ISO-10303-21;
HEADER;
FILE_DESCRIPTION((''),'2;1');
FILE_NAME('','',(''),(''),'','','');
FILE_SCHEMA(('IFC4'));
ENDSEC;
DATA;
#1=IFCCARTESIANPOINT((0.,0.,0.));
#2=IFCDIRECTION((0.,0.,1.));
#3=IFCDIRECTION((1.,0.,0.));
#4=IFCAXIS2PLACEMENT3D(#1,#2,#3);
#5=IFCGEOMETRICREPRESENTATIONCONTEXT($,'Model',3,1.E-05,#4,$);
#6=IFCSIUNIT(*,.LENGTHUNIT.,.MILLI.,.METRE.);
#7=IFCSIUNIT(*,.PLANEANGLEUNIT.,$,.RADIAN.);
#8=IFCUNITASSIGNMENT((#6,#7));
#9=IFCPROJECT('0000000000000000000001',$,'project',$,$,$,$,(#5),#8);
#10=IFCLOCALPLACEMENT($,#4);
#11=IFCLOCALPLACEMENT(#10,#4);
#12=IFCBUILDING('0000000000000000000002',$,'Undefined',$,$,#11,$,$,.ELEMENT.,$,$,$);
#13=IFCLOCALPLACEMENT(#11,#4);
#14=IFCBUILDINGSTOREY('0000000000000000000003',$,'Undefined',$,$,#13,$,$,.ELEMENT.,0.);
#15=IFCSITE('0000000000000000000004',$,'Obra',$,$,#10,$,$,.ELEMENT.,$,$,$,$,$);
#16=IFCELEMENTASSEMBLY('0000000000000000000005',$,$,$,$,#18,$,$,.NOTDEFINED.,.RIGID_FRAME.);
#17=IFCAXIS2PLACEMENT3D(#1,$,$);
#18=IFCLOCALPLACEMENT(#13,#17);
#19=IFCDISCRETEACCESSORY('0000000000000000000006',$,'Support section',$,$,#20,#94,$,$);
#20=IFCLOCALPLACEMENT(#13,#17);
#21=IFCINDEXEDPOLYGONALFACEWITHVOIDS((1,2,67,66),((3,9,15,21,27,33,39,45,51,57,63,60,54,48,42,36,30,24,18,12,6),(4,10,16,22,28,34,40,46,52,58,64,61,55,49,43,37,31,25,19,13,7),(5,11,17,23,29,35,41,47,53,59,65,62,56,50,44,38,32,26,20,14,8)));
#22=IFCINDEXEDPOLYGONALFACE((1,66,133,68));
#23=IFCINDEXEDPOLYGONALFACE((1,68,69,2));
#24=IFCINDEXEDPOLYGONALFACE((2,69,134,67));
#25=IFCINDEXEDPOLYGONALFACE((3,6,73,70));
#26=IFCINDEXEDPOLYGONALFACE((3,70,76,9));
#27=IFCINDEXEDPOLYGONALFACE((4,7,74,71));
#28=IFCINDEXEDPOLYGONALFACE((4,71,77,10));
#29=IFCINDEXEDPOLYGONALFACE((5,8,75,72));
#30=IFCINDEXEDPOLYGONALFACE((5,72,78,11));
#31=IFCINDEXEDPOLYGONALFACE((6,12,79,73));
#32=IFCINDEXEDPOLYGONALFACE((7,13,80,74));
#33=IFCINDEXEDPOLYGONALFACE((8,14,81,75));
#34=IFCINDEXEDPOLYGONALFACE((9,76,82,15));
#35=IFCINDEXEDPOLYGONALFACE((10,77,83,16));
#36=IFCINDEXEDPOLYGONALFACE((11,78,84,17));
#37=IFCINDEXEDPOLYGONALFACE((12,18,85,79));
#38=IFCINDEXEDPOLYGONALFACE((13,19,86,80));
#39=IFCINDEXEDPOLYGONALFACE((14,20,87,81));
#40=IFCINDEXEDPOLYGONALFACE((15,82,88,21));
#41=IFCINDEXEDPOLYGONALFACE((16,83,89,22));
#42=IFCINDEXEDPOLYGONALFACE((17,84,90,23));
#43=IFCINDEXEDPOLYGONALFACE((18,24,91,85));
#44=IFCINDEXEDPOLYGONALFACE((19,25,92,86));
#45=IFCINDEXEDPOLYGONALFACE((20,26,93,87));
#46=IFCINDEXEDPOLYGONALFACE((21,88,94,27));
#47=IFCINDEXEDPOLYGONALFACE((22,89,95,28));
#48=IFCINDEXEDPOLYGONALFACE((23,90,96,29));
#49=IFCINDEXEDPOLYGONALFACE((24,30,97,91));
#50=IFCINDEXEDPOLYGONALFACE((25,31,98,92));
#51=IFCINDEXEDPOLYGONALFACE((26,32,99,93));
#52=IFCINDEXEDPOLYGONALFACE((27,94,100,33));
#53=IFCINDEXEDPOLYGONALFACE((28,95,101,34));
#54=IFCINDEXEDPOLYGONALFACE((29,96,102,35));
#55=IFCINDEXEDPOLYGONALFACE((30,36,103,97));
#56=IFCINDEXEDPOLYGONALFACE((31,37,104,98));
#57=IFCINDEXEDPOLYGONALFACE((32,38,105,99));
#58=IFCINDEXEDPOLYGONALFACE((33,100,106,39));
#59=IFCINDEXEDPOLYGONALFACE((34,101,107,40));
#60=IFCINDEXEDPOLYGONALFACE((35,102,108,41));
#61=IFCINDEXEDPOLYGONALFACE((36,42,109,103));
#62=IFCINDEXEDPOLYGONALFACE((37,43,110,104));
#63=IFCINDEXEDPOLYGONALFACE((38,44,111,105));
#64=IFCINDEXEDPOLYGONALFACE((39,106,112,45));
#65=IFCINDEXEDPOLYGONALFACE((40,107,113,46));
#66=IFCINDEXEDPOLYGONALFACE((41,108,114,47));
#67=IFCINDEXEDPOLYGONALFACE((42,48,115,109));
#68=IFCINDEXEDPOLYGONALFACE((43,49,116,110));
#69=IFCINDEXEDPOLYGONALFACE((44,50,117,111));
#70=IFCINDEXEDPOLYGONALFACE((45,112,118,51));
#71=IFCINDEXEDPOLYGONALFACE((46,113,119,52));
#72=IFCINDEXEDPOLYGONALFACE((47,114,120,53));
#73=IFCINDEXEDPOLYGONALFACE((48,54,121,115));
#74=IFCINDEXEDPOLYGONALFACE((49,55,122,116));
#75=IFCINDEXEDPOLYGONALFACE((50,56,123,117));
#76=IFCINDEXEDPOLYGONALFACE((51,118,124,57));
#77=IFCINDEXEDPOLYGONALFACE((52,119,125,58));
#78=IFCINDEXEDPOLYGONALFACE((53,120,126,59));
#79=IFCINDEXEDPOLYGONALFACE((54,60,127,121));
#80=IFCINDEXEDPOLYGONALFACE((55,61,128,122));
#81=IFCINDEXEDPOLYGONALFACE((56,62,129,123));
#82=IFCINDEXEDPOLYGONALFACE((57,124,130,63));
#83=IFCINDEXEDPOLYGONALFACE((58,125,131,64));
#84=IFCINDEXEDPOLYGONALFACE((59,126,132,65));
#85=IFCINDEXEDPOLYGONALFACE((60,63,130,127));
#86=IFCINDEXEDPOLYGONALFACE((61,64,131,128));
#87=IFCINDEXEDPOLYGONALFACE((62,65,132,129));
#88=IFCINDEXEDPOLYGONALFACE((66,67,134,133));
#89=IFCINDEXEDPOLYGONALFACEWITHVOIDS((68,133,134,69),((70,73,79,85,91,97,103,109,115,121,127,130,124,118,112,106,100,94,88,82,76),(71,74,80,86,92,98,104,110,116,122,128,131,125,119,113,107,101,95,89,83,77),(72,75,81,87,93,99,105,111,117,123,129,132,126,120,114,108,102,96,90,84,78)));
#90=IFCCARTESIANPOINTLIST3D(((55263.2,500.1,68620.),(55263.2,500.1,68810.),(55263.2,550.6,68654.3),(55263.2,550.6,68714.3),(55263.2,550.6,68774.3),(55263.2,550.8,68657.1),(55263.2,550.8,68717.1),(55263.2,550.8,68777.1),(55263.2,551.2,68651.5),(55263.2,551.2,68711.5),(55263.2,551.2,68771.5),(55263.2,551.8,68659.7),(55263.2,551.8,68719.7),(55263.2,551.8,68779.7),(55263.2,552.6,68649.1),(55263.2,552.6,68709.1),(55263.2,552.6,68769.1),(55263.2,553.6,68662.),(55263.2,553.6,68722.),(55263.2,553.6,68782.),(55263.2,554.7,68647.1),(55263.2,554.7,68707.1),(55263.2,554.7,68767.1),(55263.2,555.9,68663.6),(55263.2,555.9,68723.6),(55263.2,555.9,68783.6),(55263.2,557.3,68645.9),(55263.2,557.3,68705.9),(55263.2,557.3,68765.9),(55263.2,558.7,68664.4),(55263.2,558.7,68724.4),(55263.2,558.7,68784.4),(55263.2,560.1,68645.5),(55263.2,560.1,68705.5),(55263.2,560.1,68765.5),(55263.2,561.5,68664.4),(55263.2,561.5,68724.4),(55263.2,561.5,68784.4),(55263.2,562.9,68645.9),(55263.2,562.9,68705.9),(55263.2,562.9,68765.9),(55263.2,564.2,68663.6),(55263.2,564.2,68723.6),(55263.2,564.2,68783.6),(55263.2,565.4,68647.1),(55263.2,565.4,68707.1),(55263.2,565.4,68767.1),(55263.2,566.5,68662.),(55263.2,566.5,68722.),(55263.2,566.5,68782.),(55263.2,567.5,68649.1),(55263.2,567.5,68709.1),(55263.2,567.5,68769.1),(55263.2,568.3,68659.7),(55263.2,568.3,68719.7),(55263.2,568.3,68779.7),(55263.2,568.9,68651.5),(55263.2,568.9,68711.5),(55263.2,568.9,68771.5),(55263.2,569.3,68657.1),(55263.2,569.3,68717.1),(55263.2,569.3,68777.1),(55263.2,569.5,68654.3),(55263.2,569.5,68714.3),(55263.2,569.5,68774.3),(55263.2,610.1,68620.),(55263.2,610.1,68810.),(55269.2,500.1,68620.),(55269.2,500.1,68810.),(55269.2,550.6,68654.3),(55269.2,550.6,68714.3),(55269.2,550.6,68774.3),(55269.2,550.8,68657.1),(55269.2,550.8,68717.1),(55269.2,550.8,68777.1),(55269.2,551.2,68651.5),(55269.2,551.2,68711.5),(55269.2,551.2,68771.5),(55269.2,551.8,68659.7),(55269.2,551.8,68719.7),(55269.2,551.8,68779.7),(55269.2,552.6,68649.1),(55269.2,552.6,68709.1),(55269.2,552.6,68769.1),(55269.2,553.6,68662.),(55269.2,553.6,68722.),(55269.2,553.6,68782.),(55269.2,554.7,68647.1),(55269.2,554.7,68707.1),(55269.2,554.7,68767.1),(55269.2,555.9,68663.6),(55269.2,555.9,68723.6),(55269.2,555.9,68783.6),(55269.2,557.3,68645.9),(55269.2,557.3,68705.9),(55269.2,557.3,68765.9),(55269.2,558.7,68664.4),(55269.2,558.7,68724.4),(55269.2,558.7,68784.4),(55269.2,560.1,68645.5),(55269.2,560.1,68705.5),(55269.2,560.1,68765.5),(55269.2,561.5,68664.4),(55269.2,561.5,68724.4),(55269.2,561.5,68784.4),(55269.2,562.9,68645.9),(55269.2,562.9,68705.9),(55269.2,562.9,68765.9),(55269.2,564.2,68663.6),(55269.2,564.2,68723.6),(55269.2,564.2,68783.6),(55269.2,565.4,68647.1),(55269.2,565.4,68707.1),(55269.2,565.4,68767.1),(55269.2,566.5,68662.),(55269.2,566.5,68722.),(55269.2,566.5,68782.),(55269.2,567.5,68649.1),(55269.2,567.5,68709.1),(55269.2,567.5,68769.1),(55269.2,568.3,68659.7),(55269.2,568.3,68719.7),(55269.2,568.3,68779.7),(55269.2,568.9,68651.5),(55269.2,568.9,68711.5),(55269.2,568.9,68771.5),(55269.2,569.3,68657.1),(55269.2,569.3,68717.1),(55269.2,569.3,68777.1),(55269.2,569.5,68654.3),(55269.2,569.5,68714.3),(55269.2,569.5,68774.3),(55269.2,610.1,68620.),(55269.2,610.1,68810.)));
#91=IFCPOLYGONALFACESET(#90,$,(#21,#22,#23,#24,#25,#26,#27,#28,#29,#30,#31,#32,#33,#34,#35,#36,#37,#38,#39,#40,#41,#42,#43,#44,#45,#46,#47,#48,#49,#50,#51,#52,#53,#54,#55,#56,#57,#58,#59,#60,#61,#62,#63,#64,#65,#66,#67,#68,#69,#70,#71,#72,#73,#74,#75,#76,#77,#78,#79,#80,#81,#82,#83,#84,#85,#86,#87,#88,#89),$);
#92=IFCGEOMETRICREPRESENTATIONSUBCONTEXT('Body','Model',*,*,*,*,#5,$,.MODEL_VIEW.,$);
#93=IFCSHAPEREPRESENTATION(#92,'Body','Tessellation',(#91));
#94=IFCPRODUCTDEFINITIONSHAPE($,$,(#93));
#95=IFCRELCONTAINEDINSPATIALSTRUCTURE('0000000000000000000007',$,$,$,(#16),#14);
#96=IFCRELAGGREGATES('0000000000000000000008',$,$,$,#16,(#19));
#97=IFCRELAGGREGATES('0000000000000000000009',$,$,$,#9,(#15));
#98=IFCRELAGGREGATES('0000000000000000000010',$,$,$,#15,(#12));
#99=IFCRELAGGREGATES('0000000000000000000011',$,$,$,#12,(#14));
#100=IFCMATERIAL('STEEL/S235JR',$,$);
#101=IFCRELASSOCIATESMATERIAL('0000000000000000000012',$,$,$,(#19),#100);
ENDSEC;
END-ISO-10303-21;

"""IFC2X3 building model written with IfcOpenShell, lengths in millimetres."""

from ifc_helpers import new_model, si_unit, frame, origin_with_axes, origin_2d_with_axis, place, context, subcontext, project, spatial, rectangle, circle, extrude, source, transform, mapped, material, element, aggregate, save


model = new_model("IFC2X3")

# Units and contexts
model_context = context("Model", 3, precision=1e-05, world=origin_with_axes())
body_context = subcontext(model_context, "Body", "Model", "MODEL_VIEW")
ifc_project = project(units=[si_unit("LENGTHUNIT", "METRE", prefix="MILLI"), si_unit("PLANEANGLEUNIT", "RADIAN")], contexts=[model_context])

# Site, building, storey
site_placement = place(None, origin_with_axes())
site = spatial("IfcSite", under=ifc_project, at=site_placement, Name="Obra", CompositionType="ELEMENT")
building_placement = place(site_placement, origin_with_axes())
building = spatial("IfcBuilding", under=site, at=building_placement, Name="Undefined", CompositionType="ELEMENT")
storey_placement = place(building_placement, origin_with_axes())
storey = spatial("IfcBuildingStorey", under=building, at=storey_placement, Name="Undefined", CompositionType="ELEMENT", Elevation=0.0)

# Element assembly
ifc_material_1 = material(Name="STEEL/S235JR")
assembly_1_placement = place(storey_placement, origin_with_axes())
assembly_1 = element("IfcElementAssembly", 1, at=assembly_1_placement, inside=storey, AssemblyPlace="NOTDEFINED", PredefinedType="RIGID_FRAME")

# Shared definitions
shared_shape_1 = source(origin_with_axes(), body_context, "Body", "SweptSolid", [
    extrude(circle(Radius=9.5, at=origin_2d_with_axis()), frame((0.0, -9.2, 0.0), z_axis=(0.0, 1.0, 0.0), x_axis=(1.0, 0.0, 0.0)), (0.0, 0.0, 1.0), 6.2),
])

# Discrete accessory, opening
discrete_accessory_1_placement = place(assembly_1_placement, frame((55266.2, 555.1, 68620.0), z_axis=(0.0, 0.0, 1.0), x_axis=(0.000002, -1.0, 0.0)))
discrete_accessory_1 = element("IfcDiscreteAccessory", 2, at=discrete_accessory_1_placement, material=ifc_material_1, Name="Support section", context=body_context, shape_type="SweptSolid", body=[
    extrude(rectangle(XDim=6.0, YDim=110.0, at=origin_2d_with_axis()), frame((0.0, 0.0, 190.0), z_axis=(0.0, 0.0, -1.0), x_axis=(0.0, 1.0, 0.0)), (0.0, 0.0, 1.0), 190.0),
])
opening_1_placement = place(assembly_1_placement, frame((55260.1, 510.1, 68835.0), z_axis=(-0.000002, 1.0, 0.0), x_axis=(0.0, 0.0, -1.0)))
element("IfcOpeningElement", 3, at=opening_1_placement, cuts=discrete_accessory_1, ObjectType="Opening", context=body_context, shape_type="MappedRepresentation", body=[
    mapped(shared_shape_1, transform((60.0, 0.0, 50.0))),
    mapped(shared_shape_1, transform((120.0, 0.0, 50.0))),
    mapped(shared_shape_1, transform((180.0, 0.0, 50.0))),
])
aggregate(assembly_1, [discrete_accessory_1])

save(model, "model.ifc")
